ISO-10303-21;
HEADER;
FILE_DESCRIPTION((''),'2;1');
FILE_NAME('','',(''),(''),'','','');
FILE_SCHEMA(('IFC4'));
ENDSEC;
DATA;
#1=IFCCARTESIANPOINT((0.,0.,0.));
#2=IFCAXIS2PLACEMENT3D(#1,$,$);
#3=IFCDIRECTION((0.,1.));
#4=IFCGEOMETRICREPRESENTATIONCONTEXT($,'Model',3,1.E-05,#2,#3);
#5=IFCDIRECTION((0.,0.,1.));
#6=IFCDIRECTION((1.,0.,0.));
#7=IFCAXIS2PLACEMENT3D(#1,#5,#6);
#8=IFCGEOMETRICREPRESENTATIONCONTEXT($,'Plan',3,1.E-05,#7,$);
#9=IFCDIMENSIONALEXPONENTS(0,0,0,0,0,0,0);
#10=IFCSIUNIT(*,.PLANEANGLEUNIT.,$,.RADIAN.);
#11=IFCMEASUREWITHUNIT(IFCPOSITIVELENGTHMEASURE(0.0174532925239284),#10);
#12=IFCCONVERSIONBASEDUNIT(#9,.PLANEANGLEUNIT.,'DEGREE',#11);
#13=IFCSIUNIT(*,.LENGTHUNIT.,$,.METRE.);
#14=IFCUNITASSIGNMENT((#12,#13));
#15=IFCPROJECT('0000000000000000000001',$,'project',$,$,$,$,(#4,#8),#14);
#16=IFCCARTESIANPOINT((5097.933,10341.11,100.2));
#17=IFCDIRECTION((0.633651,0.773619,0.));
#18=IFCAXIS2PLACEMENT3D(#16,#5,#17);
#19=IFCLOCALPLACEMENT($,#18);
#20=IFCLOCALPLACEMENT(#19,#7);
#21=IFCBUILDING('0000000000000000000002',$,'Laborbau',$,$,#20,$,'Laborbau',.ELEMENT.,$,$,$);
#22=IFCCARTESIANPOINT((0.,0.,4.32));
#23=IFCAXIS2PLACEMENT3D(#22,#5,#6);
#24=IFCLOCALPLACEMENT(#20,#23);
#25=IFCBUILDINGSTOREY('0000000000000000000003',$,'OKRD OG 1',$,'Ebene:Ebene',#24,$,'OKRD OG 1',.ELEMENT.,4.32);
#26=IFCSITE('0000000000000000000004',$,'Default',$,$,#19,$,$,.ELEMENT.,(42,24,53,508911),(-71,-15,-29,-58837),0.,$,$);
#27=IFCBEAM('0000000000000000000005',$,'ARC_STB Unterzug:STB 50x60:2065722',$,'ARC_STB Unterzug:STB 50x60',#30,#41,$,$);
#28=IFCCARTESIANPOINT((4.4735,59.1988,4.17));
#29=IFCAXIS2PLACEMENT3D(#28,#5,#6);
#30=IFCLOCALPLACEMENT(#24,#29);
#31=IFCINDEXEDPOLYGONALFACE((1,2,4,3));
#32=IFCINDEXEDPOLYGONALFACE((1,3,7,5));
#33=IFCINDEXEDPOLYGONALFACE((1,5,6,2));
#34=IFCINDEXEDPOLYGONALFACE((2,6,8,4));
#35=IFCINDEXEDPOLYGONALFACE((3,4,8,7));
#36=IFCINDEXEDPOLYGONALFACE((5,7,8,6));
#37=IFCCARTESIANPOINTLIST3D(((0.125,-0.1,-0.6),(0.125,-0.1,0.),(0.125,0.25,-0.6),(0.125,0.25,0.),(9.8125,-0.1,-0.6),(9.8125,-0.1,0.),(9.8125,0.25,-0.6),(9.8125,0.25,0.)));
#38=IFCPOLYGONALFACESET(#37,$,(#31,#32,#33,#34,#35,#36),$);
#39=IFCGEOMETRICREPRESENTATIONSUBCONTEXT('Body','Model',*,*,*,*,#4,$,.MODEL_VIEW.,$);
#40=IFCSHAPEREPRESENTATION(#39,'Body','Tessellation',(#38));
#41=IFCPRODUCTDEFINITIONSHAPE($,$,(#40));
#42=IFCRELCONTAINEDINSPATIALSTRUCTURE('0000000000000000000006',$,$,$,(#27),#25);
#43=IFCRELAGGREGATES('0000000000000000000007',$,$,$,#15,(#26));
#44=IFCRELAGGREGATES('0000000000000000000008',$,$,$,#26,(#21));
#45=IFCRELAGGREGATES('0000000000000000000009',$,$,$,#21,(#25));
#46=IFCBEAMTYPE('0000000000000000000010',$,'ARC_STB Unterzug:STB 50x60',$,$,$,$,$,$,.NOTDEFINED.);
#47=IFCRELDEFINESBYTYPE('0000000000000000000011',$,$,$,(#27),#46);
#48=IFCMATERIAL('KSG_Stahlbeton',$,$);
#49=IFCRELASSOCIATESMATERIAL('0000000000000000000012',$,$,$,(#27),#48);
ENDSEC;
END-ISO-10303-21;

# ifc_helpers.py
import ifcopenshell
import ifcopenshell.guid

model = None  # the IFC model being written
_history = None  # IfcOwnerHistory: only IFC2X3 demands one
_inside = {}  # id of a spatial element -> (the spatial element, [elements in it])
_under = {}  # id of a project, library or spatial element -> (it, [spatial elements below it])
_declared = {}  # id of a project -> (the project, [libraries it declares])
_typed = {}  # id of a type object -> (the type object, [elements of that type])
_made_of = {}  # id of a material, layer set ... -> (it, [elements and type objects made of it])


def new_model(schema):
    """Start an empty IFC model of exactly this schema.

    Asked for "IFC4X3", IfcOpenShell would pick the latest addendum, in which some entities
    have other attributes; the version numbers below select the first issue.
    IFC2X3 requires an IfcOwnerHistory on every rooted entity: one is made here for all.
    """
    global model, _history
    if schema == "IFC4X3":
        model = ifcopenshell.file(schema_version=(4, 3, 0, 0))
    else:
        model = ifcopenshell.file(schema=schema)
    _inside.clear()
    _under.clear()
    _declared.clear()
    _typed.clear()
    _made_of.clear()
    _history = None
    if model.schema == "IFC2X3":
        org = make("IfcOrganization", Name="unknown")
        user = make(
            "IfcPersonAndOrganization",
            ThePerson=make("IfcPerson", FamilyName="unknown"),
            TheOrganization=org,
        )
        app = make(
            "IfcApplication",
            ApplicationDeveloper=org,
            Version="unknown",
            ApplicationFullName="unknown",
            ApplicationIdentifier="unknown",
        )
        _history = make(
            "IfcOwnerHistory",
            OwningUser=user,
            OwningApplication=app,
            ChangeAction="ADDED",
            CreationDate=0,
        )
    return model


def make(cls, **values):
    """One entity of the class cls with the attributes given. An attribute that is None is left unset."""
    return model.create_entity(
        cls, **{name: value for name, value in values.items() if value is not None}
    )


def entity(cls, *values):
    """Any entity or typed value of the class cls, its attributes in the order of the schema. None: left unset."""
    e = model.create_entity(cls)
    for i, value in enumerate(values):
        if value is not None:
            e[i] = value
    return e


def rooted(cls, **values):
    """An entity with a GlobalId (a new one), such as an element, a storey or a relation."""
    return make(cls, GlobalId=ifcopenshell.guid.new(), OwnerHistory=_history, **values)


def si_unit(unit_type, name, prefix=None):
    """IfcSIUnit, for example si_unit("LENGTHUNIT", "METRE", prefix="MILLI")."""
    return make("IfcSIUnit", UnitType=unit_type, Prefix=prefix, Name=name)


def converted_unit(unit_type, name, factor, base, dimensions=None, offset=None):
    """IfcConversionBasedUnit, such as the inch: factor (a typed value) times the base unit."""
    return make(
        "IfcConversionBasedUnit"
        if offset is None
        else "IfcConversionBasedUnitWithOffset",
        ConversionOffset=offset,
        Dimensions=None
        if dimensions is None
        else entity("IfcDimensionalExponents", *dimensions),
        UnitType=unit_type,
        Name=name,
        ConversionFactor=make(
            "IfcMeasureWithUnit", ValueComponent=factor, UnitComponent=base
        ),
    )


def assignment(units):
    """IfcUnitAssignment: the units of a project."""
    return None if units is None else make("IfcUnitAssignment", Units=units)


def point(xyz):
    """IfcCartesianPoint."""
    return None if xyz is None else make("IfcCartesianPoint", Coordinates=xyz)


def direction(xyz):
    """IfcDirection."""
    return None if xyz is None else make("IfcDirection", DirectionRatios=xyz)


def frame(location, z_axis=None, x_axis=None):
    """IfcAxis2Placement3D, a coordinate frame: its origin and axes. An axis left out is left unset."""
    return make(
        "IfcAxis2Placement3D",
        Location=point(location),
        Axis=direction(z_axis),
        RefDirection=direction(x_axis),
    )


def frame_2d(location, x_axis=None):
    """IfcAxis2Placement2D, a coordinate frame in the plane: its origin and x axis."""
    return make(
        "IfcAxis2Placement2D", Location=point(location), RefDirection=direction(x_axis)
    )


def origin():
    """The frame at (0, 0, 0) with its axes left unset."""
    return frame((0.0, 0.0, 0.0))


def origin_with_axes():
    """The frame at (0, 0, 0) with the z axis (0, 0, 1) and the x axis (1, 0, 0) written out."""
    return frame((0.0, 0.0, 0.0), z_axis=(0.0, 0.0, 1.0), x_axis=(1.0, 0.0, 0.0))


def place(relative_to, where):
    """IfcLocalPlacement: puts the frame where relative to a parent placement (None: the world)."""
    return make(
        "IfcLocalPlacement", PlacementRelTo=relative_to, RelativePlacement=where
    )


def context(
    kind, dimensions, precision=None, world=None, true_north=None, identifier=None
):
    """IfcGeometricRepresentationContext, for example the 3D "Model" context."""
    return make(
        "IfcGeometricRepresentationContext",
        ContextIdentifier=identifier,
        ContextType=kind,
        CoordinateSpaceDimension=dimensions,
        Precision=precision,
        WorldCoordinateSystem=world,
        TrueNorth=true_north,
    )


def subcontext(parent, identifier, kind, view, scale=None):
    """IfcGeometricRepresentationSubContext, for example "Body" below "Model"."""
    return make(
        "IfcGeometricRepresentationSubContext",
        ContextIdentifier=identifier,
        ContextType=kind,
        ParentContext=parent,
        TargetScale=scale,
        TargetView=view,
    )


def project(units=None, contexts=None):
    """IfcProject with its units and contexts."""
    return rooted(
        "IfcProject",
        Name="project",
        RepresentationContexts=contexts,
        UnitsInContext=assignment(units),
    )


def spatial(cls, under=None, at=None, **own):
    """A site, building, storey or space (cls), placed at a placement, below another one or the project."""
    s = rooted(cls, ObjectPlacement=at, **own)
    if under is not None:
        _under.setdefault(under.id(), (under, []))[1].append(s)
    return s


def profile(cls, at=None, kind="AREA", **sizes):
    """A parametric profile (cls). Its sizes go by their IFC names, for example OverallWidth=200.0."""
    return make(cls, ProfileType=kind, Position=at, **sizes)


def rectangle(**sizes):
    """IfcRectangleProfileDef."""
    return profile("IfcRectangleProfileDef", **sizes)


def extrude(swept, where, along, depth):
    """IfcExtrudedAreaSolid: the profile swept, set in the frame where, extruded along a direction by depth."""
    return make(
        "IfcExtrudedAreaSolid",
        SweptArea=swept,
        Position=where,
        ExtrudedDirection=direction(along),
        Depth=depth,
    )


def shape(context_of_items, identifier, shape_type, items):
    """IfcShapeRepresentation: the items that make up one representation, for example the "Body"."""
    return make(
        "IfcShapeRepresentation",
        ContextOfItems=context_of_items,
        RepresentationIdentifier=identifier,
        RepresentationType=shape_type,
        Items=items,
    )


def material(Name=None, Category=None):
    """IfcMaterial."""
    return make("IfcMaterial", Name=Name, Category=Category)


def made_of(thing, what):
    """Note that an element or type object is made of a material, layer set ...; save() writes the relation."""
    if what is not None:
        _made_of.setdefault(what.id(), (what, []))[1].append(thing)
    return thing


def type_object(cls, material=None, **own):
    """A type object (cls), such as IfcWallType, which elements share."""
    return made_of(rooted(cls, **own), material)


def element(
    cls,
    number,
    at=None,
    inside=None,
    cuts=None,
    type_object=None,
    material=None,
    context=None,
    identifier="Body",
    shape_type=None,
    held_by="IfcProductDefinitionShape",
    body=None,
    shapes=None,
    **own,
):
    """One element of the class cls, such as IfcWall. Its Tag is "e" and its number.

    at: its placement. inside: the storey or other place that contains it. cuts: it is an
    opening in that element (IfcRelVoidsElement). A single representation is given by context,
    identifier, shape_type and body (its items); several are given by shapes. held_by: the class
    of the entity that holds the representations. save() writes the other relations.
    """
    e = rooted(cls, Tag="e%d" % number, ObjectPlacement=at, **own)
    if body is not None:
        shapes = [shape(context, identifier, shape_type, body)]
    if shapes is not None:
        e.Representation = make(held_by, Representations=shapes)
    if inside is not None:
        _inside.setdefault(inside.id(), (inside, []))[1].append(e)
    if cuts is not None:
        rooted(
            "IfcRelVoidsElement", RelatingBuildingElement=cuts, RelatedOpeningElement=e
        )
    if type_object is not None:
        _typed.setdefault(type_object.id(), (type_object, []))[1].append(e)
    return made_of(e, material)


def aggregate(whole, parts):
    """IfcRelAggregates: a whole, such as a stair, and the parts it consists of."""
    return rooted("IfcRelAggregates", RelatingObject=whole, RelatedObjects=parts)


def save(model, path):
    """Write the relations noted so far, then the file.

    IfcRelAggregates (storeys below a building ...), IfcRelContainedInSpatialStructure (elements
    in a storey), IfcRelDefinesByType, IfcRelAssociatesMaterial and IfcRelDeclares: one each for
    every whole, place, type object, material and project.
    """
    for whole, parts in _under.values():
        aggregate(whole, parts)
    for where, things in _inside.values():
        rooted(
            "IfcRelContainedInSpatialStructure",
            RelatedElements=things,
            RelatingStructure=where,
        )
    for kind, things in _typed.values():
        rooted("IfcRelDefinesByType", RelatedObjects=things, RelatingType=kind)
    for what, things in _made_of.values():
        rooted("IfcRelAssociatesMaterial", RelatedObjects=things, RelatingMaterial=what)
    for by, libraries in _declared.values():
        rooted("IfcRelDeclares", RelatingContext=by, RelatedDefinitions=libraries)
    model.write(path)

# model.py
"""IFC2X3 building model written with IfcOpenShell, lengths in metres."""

from ifc_helpers import new_model, entity, si_unit, converted_unit, direction, frame, frame_2d, origin, origin_with_axes, place, context, subcontext, project, spatial, rectangle, extrude, material, type_object, element, save


model = new_model("IFC2X3")

# Units and contexts
model_context = context("Model", 3, precision=1e-05, world=origin(), true_north=direction((0.0, 1.0)))
plan_context = context("Plan", 3, precision=1e-05, world=origin_with_axes())
body_context = subcontext(model_context, "Body", "Model", "MODEL_VIEW")
ifc_project = project(units=[converted_unit("PLANEANGLEUNIT", "DEGREE", entity("IfcPositiveLengthMeasure", 0.0174532925239284), si_unit("PLANEANGLEUNIT", "RADIAN"), dimensions=[0, 0, 0, 0, 0, 0, 0]), si_unit("LENGTHUNIT", "METRE")], contexts=[model_context, plan_context])

# Site, building, storey
site_placement = place(None, frame((5097.933, 10341.11, 100.2), z_axis=(0.0, 0.0, 1.0), x_axis=(0.633651, 0.773619, 0.0)))
site = spatial("IfcSite", under=ifc_project, at=site_placement, Name="Default", CompositionType="ELEMENT", RefLatitude=(42, 24, 53, 508911), RefLongitude=(-71, -15, -29, -58837), RefElevation=0.0)
building_placement = place(site_placement, origin_with_axes())
building = spatial("IfcBuilding", under=site, at=building_placement, Name="Laborbau", LongName="Laborbau", CompositionType="ELEMENT")
storey_placement = place(building_placement, frame((0.0, 0.0, 4.32), z_axis=(0.0, 0.0, 1.0), x_axis=(1.0, 0.0, 0.0)))
storey = spatial("IfcBuildingStorey", under=building, at=storey_placement, Name="OKRD OG 1", ObjectType="Ebene:Ebene", LongName="OKRD OG 1", CompositionType="ELEMENT", Elevation=4.32)

# Beam
ifc_material_1 = material(Name="KSG_Stahlbeton")
beam_type_1 = type_object("IfcBeamType", Name="ARC_STB Unterzug:STB 50x60", PredefinedType="NOTDEFINED")
beam_1_placement = place(storey_placement, frame((4.4735, 59.1988, 4.17), z_axis=(0.0, 0.0, 1.0), x_axis=(1.0, 0.0, 0.0)))
element("IfcBeam", 1, at=beam_1_placement, inside=storey, type_object=beam_type_1, material=ifc_material_1, Name="ARC_STB Unterzug:STB 50x60:2065722", ObjectType="ARC_STB Unterzug:STB 50x60", context=body_context, shape_type="SweptSolid", body=[
    extrude(rectangle(XDim=0.6, YDim=0.35, at=frame_2d((0.0, 0.0), x_axis=(1.0, 0.0))), frame((0.125, 0.075, -0.3), z_axis=(1.0, 0.0, 0.0), x_axis=(0.0, 0.0, -1.0)), (0.0, 0.0, 1.0), 9.6875),
])

save(model, "model.ifc")
